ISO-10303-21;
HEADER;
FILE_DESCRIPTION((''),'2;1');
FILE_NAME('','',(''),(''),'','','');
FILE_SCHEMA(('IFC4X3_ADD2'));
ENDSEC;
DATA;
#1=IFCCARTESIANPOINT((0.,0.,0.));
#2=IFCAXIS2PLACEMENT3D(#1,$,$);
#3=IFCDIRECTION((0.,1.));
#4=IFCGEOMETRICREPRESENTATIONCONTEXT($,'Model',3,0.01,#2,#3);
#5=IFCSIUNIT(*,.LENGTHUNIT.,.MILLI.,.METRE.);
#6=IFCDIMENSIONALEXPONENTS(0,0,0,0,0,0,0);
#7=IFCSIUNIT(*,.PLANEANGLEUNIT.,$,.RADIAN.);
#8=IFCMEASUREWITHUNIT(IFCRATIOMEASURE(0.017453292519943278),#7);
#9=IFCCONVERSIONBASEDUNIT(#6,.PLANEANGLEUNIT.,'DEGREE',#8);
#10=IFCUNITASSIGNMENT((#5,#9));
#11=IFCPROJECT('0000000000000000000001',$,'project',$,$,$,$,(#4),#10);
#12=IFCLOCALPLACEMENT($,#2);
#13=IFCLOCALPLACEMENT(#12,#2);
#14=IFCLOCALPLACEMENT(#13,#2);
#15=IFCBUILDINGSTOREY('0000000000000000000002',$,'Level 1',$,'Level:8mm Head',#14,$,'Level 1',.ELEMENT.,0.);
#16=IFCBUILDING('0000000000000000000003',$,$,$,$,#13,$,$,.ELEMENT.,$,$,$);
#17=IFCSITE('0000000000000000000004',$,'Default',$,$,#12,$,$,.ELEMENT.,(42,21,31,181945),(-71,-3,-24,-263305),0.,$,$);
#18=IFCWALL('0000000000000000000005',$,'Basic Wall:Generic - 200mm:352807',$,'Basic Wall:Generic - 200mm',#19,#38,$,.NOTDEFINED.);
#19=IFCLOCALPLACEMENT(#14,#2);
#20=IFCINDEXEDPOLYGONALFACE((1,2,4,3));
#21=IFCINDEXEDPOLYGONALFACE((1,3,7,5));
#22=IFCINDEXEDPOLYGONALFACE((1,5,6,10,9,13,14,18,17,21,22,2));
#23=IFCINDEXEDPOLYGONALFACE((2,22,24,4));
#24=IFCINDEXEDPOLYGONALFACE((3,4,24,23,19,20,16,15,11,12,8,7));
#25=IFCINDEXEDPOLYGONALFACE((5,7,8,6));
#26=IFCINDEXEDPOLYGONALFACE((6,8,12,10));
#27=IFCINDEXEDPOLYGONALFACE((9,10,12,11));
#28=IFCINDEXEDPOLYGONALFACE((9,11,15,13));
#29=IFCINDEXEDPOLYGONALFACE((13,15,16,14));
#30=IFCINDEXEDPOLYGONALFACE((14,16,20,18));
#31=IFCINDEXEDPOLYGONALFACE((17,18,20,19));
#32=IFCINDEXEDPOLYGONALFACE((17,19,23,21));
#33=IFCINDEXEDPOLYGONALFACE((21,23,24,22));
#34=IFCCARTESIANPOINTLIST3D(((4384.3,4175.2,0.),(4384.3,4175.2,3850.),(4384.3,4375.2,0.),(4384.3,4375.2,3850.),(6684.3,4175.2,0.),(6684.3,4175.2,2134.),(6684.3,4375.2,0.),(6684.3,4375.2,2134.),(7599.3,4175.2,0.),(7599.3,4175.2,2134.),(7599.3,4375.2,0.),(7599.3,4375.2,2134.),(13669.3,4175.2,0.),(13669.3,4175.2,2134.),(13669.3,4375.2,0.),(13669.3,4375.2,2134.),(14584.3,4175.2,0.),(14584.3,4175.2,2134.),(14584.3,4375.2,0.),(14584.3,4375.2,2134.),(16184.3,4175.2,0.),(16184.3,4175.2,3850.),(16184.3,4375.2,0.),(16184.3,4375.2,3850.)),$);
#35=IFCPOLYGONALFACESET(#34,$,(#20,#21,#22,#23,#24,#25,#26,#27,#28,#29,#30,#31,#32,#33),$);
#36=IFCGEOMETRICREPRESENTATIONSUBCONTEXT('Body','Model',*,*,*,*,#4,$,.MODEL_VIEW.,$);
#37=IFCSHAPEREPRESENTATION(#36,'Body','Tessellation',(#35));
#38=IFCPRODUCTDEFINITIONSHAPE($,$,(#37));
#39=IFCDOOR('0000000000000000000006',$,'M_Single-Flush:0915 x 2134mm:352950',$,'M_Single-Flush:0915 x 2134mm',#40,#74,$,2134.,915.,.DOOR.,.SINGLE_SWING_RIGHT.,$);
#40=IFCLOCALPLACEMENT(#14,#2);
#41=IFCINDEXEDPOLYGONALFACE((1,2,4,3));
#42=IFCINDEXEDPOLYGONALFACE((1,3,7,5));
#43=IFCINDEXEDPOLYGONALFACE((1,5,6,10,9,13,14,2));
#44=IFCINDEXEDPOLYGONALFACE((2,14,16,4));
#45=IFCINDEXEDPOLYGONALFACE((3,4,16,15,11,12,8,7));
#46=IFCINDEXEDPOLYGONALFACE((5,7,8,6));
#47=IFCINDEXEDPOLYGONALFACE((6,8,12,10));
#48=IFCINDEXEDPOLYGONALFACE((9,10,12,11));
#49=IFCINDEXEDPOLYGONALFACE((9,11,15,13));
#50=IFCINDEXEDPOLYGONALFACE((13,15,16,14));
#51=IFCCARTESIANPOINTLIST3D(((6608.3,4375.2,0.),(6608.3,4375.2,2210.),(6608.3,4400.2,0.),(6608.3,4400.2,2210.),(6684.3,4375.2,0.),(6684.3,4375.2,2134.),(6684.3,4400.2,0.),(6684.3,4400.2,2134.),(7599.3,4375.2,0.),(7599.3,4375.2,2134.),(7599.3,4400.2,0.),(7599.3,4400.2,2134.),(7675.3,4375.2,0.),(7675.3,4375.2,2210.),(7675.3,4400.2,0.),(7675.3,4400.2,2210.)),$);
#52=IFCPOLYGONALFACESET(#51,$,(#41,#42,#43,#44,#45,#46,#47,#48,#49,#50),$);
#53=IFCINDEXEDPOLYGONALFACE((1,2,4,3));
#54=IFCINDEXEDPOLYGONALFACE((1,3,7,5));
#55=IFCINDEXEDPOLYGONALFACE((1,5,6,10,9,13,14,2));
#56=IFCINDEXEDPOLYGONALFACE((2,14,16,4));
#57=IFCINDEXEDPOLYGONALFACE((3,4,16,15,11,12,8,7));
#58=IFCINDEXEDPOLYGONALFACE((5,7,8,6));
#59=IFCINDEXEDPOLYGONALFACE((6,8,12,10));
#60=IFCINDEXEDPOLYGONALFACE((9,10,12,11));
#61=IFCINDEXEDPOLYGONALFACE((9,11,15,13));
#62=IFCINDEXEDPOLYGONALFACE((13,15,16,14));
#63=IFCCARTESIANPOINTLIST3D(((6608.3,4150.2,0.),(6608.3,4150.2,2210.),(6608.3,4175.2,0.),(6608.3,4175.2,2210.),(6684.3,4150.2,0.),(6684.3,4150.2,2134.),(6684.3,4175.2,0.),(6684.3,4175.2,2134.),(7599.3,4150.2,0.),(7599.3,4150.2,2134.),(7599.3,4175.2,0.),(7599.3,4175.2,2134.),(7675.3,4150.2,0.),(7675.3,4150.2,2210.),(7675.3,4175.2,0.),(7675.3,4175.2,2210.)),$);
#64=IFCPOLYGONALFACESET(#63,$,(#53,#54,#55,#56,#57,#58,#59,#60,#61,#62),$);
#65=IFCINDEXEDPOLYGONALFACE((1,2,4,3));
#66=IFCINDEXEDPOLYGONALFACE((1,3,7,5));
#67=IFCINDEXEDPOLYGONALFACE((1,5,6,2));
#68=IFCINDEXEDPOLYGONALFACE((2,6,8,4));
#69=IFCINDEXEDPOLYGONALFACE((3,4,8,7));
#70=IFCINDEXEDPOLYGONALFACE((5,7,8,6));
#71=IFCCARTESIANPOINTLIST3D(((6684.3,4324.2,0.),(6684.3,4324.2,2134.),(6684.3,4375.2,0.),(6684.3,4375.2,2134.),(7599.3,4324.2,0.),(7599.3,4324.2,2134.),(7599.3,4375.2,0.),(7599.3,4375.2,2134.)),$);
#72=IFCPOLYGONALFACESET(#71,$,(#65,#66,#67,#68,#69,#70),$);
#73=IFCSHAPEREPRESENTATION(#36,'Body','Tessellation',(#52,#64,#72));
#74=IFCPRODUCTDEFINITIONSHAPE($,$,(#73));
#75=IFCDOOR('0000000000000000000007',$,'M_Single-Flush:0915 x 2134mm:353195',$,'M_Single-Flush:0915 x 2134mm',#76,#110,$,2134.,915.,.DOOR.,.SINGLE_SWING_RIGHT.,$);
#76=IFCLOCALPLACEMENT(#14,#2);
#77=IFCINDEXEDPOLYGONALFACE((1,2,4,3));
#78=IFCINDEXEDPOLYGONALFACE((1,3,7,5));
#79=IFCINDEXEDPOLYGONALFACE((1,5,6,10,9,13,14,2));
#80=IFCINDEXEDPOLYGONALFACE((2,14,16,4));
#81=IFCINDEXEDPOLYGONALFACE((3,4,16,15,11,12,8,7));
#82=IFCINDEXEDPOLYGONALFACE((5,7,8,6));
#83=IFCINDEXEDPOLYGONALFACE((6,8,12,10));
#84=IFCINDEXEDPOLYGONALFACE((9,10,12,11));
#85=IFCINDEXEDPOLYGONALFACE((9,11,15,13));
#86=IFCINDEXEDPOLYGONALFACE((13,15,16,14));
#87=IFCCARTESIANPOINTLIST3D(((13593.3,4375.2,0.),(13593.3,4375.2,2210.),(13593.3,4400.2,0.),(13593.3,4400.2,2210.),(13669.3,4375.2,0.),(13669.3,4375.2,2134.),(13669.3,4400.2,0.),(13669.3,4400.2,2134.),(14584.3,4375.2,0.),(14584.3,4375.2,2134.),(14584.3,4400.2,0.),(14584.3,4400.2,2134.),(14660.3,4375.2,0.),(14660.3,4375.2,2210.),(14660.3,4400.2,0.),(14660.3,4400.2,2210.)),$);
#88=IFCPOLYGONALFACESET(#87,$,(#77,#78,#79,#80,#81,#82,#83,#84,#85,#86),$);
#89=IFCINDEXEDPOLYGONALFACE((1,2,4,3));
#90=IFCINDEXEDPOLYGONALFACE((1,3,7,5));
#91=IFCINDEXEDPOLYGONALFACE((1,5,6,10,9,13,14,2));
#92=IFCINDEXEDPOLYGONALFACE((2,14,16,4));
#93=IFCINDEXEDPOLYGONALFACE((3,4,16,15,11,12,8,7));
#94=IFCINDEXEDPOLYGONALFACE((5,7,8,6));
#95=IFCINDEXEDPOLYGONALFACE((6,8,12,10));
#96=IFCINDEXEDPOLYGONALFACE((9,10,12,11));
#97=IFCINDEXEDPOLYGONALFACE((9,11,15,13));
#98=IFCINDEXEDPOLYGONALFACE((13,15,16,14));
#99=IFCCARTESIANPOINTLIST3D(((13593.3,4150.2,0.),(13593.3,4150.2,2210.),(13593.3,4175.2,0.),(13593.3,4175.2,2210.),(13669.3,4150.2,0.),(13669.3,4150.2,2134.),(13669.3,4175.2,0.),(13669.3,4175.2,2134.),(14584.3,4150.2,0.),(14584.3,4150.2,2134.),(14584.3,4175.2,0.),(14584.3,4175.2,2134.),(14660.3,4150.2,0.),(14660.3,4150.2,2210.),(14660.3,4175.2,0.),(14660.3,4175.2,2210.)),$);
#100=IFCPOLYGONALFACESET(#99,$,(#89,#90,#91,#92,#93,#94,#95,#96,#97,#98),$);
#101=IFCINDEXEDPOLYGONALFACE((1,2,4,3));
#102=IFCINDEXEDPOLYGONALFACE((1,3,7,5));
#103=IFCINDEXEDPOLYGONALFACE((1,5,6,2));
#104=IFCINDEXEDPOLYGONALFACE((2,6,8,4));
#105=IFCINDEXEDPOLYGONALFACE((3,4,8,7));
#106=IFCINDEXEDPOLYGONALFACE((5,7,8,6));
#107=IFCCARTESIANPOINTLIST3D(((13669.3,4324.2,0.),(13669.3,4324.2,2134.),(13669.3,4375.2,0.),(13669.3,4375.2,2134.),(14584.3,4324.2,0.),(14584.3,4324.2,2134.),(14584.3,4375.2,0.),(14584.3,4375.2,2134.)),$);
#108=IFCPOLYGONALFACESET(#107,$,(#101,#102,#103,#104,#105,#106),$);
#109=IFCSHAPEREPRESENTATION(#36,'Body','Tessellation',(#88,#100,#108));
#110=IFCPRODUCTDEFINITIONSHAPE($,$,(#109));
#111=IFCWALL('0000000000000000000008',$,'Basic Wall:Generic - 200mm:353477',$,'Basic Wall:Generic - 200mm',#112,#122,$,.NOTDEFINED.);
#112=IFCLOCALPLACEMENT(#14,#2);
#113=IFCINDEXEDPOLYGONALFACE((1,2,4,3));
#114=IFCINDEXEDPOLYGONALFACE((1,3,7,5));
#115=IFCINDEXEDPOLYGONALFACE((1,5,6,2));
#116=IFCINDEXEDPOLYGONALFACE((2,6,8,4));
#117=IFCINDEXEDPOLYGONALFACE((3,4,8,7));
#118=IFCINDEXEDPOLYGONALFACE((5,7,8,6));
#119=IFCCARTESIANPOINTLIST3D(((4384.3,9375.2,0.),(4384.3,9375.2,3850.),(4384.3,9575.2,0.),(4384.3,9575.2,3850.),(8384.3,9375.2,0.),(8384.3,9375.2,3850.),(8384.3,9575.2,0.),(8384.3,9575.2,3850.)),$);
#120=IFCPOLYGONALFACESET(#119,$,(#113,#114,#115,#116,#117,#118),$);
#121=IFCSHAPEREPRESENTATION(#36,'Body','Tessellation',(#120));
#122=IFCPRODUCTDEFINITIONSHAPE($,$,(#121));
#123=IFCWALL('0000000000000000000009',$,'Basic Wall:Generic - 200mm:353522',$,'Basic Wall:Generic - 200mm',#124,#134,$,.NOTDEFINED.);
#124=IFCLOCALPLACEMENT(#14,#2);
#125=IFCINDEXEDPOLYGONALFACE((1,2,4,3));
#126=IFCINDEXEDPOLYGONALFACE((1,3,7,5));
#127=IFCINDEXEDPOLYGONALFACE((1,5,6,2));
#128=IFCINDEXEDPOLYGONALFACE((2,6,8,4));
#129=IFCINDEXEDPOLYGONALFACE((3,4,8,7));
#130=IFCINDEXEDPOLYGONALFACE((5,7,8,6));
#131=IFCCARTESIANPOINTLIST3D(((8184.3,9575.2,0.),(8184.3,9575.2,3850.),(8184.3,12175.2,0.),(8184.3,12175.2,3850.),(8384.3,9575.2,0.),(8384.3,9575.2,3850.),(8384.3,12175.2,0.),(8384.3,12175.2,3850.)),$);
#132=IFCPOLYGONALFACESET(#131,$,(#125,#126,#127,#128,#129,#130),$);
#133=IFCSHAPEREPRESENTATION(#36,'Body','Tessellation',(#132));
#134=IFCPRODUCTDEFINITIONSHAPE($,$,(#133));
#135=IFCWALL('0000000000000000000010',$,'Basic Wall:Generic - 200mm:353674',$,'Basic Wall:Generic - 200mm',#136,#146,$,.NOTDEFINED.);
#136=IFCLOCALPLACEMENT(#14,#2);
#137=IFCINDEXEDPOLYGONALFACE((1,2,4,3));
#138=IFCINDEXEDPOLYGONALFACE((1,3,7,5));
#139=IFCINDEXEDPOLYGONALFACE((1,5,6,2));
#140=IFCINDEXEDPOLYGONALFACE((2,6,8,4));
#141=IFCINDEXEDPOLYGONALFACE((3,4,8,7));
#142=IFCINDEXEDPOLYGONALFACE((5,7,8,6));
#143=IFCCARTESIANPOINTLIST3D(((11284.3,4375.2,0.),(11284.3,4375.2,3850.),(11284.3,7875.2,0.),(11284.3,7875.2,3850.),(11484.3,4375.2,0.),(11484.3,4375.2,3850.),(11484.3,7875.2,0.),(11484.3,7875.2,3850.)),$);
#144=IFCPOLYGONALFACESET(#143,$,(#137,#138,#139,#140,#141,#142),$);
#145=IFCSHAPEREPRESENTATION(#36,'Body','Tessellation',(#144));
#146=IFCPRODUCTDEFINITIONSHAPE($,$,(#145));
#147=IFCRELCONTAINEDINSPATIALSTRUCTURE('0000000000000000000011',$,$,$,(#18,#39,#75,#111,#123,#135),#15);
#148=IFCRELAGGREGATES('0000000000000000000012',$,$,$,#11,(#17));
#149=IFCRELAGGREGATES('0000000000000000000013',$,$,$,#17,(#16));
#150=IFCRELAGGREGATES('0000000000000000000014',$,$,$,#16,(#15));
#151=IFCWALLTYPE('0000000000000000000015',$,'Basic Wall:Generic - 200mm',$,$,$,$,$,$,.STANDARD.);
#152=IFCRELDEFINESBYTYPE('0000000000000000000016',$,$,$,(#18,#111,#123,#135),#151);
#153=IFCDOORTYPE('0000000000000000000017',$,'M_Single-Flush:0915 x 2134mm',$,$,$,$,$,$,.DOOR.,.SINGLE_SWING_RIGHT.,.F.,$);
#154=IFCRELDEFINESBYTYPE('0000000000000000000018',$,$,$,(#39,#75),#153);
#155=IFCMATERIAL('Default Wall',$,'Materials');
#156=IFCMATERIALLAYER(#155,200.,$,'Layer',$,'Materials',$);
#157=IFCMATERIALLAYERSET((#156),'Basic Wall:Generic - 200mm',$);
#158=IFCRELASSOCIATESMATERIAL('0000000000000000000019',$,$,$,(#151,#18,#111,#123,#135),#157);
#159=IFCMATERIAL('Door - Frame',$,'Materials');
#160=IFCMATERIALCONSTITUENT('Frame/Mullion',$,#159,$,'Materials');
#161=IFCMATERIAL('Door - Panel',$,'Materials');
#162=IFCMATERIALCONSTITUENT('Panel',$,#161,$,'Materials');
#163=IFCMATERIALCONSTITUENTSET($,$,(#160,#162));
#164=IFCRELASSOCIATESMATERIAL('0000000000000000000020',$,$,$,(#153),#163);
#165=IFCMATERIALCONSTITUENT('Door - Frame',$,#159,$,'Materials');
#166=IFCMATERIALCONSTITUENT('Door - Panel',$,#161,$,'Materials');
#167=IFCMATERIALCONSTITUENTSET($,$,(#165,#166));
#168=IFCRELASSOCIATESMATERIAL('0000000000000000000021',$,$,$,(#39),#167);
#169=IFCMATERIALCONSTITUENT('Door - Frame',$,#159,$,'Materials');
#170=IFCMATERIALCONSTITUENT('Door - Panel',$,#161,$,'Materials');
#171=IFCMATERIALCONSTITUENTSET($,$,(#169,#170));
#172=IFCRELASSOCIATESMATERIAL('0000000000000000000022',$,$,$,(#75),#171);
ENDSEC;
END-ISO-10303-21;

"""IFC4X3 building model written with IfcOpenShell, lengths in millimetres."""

from ifc_helpers import new_model, entity, si_unit, converted_unit, direction, frame, frame_2d, origin, place, context, subcontext, project, spatial, polyline, rectangle, outline, extrude, clip, bounded_halfspace, source, transform, mapped, material, layer, layer_set, constituent, constituent_set, type_object, type_shapes, element, fill, save


model = new_model("IFC4X3")

# Units and contexts
model_context = context("Model", 3, precision=0.01, world=origin(), true_north=direction((0.0, 1.0)))
body_context = subcontext(model_context, "Body", "Model", "MODEL_VIEW")
ifc_project = project(units=[si_unit("LENGTHUNIT", "METRE", prefix="MILLI"), converted_unit("PLANEANGLEUNIT", "DEGREE", entity("IfcRatioMeasure", 0.017453292519943278), si_unit("PLANEANGLEUNIT", "RADIAN"), dimensions=[0, 0, 0, 0, 0, 0, 0])], contexts=[model_context])

# Site, building, storey
site_placement = place(None, origin())
site = spatial("IfcSite", under=ifc_project, at=site_placement, Name="Default", CompositionType="ELEMENT", RefLatitude=(42, 21, 31, 181945), RefLongitude=(-71, -3, -24, -263305), RefElevation=0.0)
building_placement = place(site_placement, origin())
building = spatial("IfcBuilding", under=site, at=building_placement, CompositionType="ELEMENT")
storey_placement = place(building_placement, origin())
storey = spatial("IfcBuildingStorey", under=building, at=storey_placement, Name="Level 1", ObjectType="Level:8mm Head", LongName="Level 1", CompositionType="ELEMENT", Elevation=0.0)

# Shared definitions
ifc_material_1 = material(Name="Default Wall", Category="Materials")
ifc_layer_1 = layer(ifc_material_1, 200.0, Name="Layer", Category="Materials")
ifc_layer_set_1 = layer_set([ifc_layer_1], Name="Basic Wall:Generic - 200mm")
wall_type = type_object("IfcWallType", Name="Basic Wall:Generic - 200mm", PredefinedType="STANDARD", material=ifc_layer_set_1)

# Wall, openings, doors
wall_1_placement = place(storey_placement, frame((16184.3, 4275.2, 0.0), z_axis=(0.0, 0.0, 1.0), x_axis=(-1.0, 0.0, 0.0)))
wall_1 = element("IfcWall", 1, at=wall_1_placement, inside=storey, type_object=wall_type, material=ifc_layer_set_1, Name="Basic Wall:Generic - 200mm:352807", ObjectType="Basic Wall:Generic - 200mm", PredefinedType="NOTDEFINED", context=body_context, shape_type="Clipping", body=[
    clip(extrude(rectangle(XDim=11800.0, YDim=200.0, at=frame_2d((5900.0, 0.0), x_axis=(1.0, 0.0))), origin(), (0.0, 0.0, 1.0), 3850.0), bounded_halfspace(frame((0.0, -100.0, 3850.0), z_axis=(0.0, 0.0, -1.0), x_axis=(-1.0, 0.0, 0.0)), True, frame((0.0, -100.0, 3850.0)), polyline([(0.0, 0.0), (4700.0, 0.0), (4900.0, 0.0), (11800.0, 0.0), (11800.0, 200.0), (0.0, 200.0), (0.0, 0.0)]))),
])
opening_1_placement = place(wall_1_placement, frame((9500.0, 100.0, 0.0)))
opening_1 = element("IfcOpeningElement", 2, at=opening_1_placement, cuts=wall_1, PredefinedType="OPENING", context=body_context, shape_type="SweptSolid", body=[
    extrude(rectangle(XDim=915.0, YDim=2134.0, at=frame_2d((1067.0, 457.5), x_axis=(0.0, 1.0))), frame((0.0, 0.0, 0.0), z_axis=(0.0, -1.0, 0.0), x_axis=(0.0, 0.0, 1.0)), (0.0, 0.0, 1.0), 200.0),
])
opening_2_placement = place(wall_1_placement, frame((2515.0, 100.0, 0.0)))
opening_2 = element("IfcOpeningElement", 3, at=opening_2_placement, cuts=wall_1, PredefinedType="OPENING", context=body_context, shape_type="SweptSolid", body=[
    extrude(rectangle(XDim=915.0, YDim=2134.0, at=frame_2d((1067.0, 457.5), x_axis=(0.0, 1.0))), frame((0.0, 0.0, 0.0), z_axis=(0.0, -1.0, 0.0), x_axis=(0.0, 0.0, 1.0)), (0.0, 0.0, 1.0), 200.0),
])
ifc_material_2 = material(Name="Door - Frame", Category="Materials")
ifc_constituent_1 = constituent(ifc_material_2, Name="Door - Frame", Category="Materials")
ifc_material_3 = material(Name="Door - Panel", Category="Materials")
ifc_constituent_2 = constituent(ifc_material_3, Name="Door - Panel", Category="Materials")
ifc_constituent_set_1 = constituent_set(constituents=[ifc_constituent_1, ifc_constituent_2])
ifc_constituent_3 = constituent(ifc_material_2, Name="Frame/Mullion", Category="Materials")
ifc_constituent_4 = constituent(ifc_material_3, Name="Panel", Category="Materials")
ifc_constituent_set_2 = constituent_set(constituents=[ifc_constituent_3, ifc_constituent_4])
door_type = type_object("IfcDoorType", Name="M_Single-Flush:0915 x 2134mm", OperationType="SINGLE_SWING_RIGHT", ParameterTakesPrecedence=False, PredefinedType="DOOR", material=ifc_constituent_set_2)
shared_shape = source(origin(), body_context, "Body", "SweptSolid", [
    extrude(outline(polyline([(-533.5, -1124.0), (533.5, -1124.0), (533.5, 1086.0), (457.5, 1086.0), (457.5, -1048.0), (-457.5, -1048.0), (-457.5, 1086.0), (-533.5, 1086.0), (-533.5, -1124.0)])), frame((457.5, 200.0, 1086.0), z_axis=(0.0, 1.0, 0.0), x_axis=(1.0, 0.0, 0.0)), (0.0, 0.0, 1.0), 25.0),
    extrude(outline(polyline([(-1124.0, -533.5), (1086.0, -533.5), (1086.0, -457.5), (-1048.0, -457.5), (-1048.0, 457.5), (1086.0, 457.5), (1086.0, 533.5), (-1124.0, 533.5), (-1124.0, -533.5)])), frame((457.5, -25.0, 1086.0), z_axis=(0.0, 1.0, 0.0), x_axis=(0.0, 0.0, -1.0)), (0.0, 0.0, 1.0), 25.0),
    extrude(rectangle(XDim=51.0, YDim=915.0, at=frame_2d((0.0, 0.0), x_axis=(1.0, 0.0))), frame((457.5, 174.5, 0.0), z_axis=(0.0, 0.0, 1.0), x_axis=(0.0, 1.0, 0.0)), (0.0, 0.0, 1.0), 2134.0),
])
type_shapes(door_type, [shared_shape])
door_1_placement = place(opening_1_placement, frame((0.0, 0.0, 0.0), z_axis=(0.0, 0.0, 1.0), x_axis=(-1.0, 0.0, 0.0)))
door_1 = element("IfcDoor", 4, at=door_1_placement, inside=storey, type_object=door_type, material=ifc_constituent_set_1, Name="M_Single-Flush:0915 x 2134mm:352950", ObjectType="M_Single-Flush:0915 x 2134mm", OperationType="SINGLE_SWING_RIGHT", OverallHeight=2134.0, OverallWidth=915.0, PredefinedType="DOOR", context=body_context, shape_type="MappedRepresentation", body=[
    mapped(shared_shape, transform((0.0, 0.0, 0.0), scale=1.0)),
])
fill(opening_1, door_1)
ifc_constituent_5 = constituent(ifc_material_2, Name="Door - Frame", Category="Materials")
ifc_constituent_6 = constituent(ifc_material_3, Name="Door - Panel", Category="Materials")
ifc_constituent_set_3 = constituent_set(constituents=[ifc_constituent_5, ifc_constituent_6])
door_2_placement = place(opening_2_placement, frame((0.0, 0.0, 0.0), z_axis=(0.0, 0.0, 1.0), x_axis=(-1.0, 0.0, 0.0)))
door_2 = element("IfcDoor", 5, at=door_2_placement, inside=storey, type_object=door_type, material=ifc_constituent_set_3, Name="M_Single-Flush:0915 x 2134mm:353195", ObjectType="M_Single-Flush:0915 x 2134mm", OperationType="SINGLE_SWING_RIGHT", OverallHeight=2134.0, OverallWidth=915.0, PredefinedType="DOOR", context=body_context, shape_type="MappedRepresentation", body=[
    mapped(shared_shape, transform((0.0, 0.0, 0.0), scale=1.0)),
])
fill(opening_2, door_2)

# Walls
wall_2_placement = place(storey_placement, frame((4384.3, 9475.2, 0.0)))
element("IfcWall", 6, at=wall_2_placement, inside=storey, type_object=wall_type, material=ifc_layer_set_1, Name="Basic Wall:Generic - 200mm:353477", ObjectType="Basic Wall:Generic - 200mm", PredefinedType="NOTDEFINED", context=body_context, shape_type="Clipping", body=[
    clip(extrude(rectangle(XDim=4000.0, YDim=200.0, at=frame_2d((2000.0, 0.0), x_axis=(-1.0, 0.0))), origin(), (0.0, 0.0, 1.0), 3850.0), bounded_halfspace(frame((0.0, -100.0, 3850.0), z_axis=(0.0, 0.0, -1.0), x_axis=(1.0, 0.0, 0.0)), True, frame((0.0, -100.0, 3850.0)), polyline([(0.0, 0.0), (4000.0, 0.0), (4000.0, 200.0), (3800.0, 200.0), (0.0, 200.0), (0.0, 0.0)]))),
])
wall_3_placement = place(storey_placement, frame((8284.3, 9575.2, 0.0), z_axis=(0.0, 0.0, 1.0), x_axis=(0.0, 1.0, 0.0)))
element("IfcWall", 7, at=wall_3_placement, inside=storey, type_object=wall_type, material=ifc_layer_set_1, Name="Basic Wall:Generic - 200mm:353522", ObjectType="Basic Wall:Generic - 200mm", PredefinedType="NOTDEFINED", context=body_context, shape_type="Clipping", body=[
    clip(extrude(rectangle(XDim=2600.0, YDim=200.0, at=frame_2d((1300.0, 0.0), x_axis=(-1.0, 0.0))), origin(), (0.0, 0.0, 1.0), 3850.0), bounded_halfspace(frame((0.0, -100.0, 3850.0), z_axis=(0.0, 0.0, -1.0), x_axis=(0.0, -1.0, 0.0)), True, frame((0.0, -100.0, 3850.0)), polyline([(0.0, 0.0), (2600.0, 0.0), (2600.0, 200.0), (0.0, 200.0), (0.0, 0.0)]))),
])
wall_4_placement = place(storey_placement, frame((11384.3, 4375.2, 0.0), z_axis=(0.0, 0.0, 1.0), x_axis=(0.0, 1.0, 0.0)))
element("IfcWall", 8, at=wall_4_placement, inside=storey, type_object=wall_type, material=ifc_layer_set_1, Name="Basic Wall:Generic - 200mm:353674", ObjectType="Basic Wall:Generic - 200mm", PredefinedType="NOTDEFINED", context=body_context, shape_type="Clipping", body=[
    clip(extrude(rectangle(XDim=3500.0, YDim=200.0, at=frame_2d((1750.0, 0.0), x_axis=(-1.0, 0.0))), origin(), (0.0, 0.0, 1.0), 3850.0), bounded_halfspace(frame((0.0, -100.0, 3850.0), z_axis=(0.0, 0.0, -1.0), x_axis=(0.0, -1.0, 0.0)), True, frame((0.0, -100.0, 3850.0)), polyline([(0.0, 0.0), (3300.0, 0.0), (3500.0, 0.0), (3500.0, 200.0), (0.0, 200.0), (0.0, 0.0)]))),
])

save(model, "model.ifc")
